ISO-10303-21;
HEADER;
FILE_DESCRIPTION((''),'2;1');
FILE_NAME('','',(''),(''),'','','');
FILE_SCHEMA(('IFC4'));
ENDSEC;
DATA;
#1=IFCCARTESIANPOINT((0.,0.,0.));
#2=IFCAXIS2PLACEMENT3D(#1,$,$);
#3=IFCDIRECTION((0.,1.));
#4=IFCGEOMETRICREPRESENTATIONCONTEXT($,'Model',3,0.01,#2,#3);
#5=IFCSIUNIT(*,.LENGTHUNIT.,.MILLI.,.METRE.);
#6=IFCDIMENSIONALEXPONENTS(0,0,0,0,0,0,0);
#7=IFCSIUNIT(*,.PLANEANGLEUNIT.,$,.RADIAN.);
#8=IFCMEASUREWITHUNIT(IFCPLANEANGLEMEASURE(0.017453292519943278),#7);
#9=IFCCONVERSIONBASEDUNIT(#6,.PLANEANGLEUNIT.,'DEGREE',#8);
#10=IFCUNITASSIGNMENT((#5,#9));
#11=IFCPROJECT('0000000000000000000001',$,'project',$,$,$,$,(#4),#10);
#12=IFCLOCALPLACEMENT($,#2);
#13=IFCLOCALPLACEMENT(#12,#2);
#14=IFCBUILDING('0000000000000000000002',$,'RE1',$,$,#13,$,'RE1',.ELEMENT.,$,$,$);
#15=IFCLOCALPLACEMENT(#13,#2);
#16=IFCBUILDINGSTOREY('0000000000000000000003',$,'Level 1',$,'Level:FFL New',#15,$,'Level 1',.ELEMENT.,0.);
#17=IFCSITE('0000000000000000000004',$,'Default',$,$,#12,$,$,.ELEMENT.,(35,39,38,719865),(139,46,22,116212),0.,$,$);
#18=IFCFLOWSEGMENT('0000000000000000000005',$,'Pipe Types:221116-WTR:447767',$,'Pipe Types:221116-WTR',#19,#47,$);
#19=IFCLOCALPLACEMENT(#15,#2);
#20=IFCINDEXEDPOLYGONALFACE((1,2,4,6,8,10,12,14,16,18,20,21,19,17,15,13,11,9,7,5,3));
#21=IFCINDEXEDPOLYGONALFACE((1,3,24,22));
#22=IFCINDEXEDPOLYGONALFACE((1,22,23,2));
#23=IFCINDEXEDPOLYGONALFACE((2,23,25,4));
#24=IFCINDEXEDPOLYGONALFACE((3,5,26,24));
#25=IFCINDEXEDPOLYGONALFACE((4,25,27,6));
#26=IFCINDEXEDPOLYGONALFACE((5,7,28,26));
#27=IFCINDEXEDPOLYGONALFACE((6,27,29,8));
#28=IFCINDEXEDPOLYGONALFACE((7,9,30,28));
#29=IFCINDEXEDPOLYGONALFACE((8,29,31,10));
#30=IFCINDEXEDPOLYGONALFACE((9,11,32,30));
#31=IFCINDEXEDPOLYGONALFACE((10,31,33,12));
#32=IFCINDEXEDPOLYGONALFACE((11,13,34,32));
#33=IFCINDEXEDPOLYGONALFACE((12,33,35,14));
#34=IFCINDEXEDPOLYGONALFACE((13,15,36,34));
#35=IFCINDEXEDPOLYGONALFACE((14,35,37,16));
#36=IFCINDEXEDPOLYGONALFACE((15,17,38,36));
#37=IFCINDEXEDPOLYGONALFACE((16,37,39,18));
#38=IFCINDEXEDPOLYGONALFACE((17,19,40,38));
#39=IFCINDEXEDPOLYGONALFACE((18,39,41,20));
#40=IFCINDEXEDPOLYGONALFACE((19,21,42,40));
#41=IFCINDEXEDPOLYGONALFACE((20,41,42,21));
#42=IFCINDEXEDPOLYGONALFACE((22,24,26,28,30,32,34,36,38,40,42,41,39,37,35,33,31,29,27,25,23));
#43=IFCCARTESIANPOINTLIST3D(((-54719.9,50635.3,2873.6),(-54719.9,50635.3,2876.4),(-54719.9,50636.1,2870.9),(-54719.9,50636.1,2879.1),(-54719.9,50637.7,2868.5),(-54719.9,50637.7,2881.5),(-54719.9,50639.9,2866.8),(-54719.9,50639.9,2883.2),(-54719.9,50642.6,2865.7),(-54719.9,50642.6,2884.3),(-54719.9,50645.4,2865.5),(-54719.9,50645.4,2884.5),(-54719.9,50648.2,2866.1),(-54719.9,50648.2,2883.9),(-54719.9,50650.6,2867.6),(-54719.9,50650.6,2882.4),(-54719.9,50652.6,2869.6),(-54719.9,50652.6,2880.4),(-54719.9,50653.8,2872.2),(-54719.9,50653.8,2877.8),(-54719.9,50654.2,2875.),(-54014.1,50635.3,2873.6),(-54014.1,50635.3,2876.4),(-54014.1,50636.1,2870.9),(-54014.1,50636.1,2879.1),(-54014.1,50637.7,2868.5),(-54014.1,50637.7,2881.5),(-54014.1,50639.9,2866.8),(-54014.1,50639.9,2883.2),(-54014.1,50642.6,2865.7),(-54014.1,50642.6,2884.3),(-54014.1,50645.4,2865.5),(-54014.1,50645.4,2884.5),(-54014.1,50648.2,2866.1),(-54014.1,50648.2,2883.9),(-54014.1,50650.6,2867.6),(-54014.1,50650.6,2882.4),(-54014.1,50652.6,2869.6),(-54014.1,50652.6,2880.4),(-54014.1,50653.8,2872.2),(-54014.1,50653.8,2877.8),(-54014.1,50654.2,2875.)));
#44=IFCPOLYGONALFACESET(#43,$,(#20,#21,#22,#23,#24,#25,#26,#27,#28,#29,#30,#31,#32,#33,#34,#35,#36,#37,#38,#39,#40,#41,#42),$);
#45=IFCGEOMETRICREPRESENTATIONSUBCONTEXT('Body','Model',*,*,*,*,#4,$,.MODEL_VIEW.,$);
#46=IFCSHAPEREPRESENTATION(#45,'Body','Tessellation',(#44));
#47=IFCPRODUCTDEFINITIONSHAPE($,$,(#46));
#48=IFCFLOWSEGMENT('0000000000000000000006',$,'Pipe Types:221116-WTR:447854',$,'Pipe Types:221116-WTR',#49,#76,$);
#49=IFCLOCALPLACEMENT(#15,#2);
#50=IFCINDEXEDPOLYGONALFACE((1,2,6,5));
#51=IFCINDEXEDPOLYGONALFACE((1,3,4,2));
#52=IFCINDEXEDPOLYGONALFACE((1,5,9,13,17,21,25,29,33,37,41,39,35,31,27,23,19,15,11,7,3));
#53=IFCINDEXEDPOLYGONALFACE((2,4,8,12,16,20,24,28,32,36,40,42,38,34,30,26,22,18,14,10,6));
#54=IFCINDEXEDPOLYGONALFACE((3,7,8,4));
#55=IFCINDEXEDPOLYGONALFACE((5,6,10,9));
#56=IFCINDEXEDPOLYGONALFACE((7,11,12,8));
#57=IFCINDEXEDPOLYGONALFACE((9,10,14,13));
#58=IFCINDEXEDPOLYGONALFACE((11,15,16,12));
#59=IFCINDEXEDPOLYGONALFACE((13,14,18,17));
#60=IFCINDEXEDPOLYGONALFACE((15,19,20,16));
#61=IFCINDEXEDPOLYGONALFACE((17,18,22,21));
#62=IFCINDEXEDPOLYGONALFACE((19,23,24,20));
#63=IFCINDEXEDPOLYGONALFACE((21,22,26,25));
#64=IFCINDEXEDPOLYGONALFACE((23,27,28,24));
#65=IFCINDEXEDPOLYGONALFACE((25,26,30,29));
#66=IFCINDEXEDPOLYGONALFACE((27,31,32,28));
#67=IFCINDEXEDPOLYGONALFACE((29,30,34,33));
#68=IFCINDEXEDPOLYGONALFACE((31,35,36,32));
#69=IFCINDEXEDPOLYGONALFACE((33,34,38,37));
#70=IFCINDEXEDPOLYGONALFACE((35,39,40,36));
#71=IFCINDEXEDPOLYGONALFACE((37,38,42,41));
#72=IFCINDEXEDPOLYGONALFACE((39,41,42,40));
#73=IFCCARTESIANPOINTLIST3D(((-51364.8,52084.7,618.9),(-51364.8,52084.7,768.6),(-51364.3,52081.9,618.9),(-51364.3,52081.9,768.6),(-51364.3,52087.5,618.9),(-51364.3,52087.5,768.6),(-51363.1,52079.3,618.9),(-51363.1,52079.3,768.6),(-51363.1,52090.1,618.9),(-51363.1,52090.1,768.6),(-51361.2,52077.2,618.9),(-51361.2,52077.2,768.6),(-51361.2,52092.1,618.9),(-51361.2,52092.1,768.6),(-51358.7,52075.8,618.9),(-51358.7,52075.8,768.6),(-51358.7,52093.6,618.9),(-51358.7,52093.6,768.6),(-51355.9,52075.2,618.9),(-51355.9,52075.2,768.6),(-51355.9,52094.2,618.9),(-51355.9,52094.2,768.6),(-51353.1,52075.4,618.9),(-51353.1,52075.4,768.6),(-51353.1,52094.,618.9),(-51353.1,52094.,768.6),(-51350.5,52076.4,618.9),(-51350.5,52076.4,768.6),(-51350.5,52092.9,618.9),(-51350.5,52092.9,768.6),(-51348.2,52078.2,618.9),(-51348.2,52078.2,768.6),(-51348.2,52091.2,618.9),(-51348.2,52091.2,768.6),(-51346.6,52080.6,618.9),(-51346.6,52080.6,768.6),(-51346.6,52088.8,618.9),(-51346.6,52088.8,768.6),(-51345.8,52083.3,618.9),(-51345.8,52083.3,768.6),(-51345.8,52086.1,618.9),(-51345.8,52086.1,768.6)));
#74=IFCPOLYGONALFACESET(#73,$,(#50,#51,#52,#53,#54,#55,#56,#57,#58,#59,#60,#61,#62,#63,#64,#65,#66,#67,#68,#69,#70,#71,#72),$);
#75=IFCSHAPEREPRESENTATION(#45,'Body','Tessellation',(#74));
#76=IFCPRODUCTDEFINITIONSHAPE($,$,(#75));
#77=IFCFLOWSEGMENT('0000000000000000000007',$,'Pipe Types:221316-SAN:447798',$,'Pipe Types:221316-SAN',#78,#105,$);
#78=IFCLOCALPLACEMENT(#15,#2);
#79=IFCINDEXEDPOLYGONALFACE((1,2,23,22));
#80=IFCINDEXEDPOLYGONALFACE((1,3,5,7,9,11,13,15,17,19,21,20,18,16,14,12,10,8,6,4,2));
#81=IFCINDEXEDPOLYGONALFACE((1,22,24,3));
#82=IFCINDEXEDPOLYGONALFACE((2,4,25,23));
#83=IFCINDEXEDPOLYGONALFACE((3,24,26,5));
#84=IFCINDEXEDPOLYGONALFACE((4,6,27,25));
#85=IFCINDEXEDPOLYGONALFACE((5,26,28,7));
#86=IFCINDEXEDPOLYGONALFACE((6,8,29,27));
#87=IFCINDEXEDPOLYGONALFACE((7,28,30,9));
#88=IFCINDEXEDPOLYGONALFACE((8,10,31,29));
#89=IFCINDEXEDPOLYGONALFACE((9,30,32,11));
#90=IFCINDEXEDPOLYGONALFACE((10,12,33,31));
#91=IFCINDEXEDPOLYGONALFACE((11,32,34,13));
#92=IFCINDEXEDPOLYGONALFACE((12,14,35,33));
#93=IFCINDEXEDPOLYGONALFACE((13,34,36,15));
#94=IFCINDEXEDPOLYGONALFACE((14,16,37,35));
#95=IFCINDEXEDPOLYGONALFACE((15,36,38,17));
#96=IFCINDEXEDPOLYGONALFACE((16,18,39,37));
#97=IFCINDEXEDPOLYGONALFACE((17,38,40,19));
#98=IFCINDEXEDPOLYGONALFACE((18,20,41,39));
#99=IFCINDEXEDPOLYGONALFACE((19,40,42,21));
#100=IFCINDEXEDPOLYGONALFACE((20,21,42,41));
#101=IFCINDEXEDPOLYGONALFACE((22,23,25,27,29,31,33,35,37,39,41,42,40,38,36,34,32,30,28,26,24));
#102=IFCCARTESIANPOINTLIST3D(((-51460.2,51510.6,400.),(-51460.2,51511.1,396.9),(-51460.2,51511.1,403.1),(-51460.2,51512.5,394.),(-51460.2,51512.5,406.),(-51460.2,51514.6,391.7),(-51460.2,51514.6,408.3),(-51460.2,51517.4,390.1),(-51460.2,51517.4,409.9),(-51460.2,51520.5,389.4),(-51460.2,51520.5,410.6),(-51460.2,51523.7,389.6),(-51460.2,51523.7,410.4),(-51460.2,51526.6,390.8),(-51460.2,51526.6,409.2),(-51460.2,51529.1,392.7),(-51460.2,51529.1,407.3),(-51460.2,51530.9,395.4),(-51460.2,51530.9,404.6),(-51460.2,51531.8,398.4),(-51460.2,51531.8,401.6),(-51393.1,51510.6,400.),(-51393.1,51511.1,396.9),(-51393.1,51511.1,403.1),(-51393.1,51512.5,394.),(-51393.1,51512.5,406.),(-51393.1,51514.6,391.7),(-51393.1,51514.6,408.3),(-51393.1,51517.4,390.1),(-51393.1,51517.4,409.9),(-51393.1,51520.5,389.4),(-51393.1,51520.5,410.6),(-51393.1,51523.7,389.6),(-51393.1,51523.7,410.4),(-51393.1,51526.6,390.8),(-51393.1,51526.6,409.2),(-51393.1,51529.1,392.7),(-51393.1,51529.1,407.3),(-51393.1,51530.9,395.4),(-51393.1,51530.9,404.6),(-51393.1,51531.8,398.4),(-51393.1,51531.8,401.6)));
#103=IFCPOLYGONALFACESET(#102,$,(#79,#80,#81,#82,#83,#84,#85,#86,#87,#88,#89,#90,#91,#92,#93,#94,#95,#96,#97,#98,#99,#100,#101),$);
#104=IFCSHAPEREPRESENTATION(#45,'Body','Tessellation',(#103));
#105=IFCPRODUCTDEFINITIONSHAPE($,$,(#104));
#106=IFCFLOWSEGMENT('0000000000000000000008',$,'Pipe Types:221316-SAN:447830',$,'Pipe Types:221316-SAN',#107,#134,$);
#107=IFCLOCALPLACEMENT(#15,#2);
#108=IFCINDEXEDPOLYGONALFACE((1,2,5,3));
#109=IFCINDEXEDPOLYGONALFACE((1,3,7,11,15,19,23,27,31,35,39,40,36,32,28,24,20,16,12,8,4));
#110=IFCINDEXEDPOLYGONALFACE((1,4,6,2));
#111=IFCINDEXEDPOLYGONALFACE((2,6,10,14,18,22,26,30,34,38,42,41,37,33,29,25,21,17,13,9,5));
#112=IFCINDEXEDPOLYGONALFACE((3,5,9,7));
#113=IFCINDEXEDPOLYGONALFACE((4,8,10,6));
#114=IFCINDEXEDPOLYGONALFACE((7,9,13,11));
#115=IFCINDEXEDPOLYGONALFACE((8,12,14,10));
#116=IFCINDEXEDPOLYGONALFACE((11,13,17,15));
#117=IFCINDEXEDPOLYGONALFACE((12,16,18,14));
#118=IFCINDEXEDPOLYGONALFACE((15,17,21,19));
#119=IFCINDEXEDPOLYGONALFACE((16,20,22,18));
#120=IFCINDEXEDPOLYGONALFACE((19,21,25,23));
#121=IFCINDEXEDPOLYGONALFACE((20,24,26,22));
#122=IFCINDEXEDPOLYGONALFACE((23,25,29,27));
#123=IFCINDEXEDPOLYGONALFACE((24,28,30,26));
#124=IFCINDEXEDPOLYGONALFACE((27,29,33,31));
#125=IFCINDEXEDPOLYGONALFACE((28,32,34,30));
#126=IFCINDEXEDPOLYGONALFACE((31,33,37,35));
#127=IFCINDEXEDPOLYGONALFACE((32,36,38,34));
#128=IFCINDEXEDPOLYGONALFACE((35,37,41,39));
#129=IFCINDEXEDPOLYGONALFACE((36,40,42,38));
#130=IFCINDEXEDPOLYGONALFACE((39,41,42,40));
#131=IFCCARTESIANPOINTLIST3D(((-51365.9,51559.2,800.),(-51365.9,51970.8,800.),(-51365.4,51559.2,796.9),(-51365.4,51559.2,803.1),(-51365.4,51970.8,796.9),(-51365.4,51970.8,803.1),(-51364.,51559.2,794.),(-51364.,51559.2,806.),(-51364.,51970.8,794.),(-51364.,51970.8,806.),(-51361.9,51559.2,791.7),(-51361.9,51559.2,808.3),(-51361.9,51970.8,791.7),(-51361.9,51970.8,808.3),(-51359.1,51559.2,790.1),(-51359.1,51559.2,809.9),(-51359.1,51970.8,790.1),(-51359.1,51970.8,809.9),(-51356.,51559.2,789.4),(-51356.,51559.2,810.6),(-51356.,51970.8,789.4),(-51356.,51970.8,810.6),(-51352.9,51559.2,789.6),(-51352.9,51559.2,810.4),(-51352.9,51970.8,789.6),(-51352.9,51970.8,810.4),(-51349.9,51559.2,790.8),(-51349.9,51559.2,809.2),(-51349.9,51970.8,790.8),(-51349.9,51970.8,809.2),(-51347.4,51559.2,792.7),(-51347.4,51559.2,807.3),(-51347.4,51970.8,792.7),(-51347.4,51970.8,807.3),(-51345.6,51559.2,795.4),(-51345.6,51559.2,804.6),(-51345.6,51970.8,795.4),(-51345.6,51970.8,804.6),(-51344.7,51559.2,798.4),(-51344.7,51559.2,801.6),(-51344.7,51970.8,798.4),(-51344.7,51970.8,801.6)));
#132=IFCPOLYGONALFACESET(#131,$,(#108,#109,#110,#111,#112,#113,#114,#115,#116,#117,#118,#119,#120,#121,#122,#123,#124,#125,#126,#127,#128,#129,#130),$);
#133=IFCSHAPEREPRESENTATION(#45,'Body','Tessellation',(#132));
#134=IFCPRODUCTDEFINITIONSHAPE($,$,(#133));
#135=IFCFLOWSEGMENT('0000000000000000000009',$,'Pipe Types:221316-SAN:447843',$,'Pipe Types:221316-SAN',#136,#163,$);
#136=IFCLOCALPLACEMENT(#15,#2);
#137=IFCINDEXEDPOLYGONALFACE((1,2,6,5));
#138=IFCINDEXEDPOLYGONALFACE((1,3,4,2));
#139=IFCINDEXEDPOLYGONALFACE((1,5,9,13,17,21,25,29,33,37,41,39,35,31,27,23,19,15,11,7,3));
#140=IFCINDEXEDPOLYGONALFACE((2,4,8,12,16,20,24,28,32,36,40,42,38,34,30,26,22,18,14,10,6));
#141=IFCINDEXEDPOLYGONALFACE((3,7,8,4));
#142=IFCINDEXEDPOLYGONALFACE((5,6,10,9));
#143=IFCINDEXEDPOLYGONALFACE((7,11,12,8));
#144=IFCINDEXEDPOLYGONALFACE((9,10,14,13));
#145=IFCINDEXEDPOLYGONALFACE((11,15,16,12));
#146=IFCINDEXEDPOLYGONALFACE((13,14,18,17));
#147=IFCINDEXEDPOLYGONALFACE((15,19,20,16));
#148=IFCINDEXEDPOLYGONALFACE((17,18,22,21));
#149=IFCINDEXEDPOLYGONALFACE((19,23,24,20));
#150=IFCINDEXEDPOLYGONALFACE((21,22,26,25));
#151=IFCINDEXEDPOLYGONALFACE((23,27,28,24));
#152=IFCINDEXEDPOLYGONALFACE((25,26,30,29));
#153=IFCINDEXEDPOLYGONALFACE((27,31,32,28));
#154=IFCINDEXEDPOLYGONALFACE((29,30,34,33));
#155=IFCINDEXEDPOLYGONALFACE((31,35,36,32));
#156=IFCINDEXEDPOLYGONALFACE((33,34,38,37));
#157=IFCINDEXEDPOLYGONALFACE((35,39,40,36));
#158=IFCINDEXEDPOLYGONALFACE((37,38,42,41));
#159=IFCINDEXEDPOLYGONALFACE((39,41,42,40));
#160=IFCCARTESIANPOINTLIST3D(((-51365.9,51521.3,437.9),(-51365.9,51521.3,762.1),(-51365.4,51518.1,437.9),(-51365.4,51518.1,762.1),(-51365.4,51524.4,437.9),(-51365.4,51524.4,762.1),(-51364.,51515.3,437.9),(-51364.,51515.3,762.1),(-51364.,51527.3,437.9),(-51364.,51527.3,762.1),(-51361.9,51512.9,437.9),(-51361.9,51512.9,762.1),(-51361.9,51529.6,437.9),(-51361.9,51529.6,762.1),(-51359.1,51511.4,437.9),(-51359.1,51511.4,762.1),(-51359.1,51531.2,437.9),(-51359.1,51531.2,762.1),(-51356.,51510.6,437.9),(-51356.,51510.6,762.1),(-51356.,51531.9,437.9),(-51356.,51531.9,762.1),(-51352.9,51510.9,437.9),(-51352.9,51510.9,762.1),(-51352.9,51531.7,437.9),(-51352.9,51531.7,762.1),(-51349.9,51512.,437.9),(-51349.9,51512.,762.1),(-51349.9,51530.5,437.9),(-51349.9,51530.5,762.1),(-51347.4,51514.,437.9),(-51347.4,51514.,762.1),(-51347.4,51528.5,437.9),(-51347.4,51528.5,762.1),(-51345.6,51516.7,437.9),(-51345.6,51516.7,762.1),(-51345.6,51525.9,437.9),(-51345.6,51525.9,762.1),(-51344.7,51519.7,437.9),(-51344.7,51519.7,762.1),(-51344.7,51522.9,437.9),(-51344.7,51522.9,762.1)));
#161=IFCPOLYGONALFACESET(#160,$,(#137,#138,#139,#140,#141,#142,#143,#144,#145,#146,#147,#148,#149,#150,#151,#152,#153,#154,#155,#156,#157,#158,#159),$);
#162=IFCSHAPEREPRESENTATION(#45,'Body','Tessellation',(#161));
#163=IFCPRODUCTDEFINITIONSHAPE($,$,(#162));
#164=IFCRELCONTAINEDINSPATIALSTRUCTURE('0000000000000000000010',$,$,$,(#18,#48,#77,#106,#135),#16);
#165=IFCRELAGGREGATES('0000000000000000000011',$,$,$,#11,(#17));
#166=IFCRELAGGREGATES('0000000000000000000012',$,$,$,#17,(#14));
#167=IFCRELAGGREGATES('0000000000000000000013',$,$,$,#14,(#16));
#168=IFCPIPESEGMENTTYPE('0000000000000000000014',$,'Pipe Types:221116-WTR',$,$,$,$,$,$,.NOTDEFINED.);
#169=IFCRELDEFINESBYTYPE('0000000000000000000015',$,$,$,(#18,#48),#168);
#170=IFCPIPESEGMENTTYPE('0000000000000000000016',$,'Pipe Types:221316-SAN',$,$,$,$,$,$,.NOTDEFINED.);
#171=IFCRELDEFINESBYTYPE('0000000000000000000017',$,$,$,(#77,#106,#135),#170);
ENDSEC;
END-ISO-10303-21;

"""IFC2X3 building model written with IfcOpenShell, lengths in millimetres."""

from ifc_helpers import new_model, entity, si_unit, converted_unit, direction, frame, frame_2d, origin, origin_2d_with_axis, place, context, subcontext, project, spatial, circle, extrude, type_object, element, save


model = new_model("IFC2X3")

# Units and contexts
model_context = context("Model", 3, precision=0.01, world=origin(), true_north=direction((0.0, 1.0)))
body_context = subcontext(model_context, "Body", "Model", "MODEL_VIEW")
ifc_project = project(units=[si_unit("LENGTHUNIT", "METRE", prefix="MILLI"), converted_unit("PLANEANGLEUNIT", "DEGREE", entity("IfcPlaneAngleMeasure", 0.017453292519943278), si_unit("PLANEANGLEUNIT", "RADIAN"), dimensions=[0, 0, 0, 0, 0, 0, 0])], contexts=[model_context])

# Site, building, storey
site_placement = place(None, origin())
site = spatial("IfcSite", under=ifc_project, at=site_placement, Name="Default", CompositionType="ELEMENT", RefLatitude=(35, 39, 38, 719865), RefLongitude=(139, 46, 22, 116212), RefElevation=0.0)
building_placement = place(site_placement, origin())
building = spatial("IfcBuilding", under=site, at=building_placement, Name="RE1", LongName="RE1", CompositionType="ELEMENT")
storey_placement = place(building_placement, origin())
storey = spatial("IfcBuildingStorey", under=building, at=storey_placement, Name="Level 1", ObjectType="Level:FFL New", LongName="Level 1", CompositionType="ELEMENT", Elevation=0.0)

# Flow segments
pipe_segment_type_1 = type_object("IfcPipeSegmentType", Name="Pipe Types:221116-WTR", PredefinedType="NOTDEFINED")
flow_segment_1_placement = place(storey_placement, origin())
element("IfcFlowSegment", 1, at=flow_segment_1_placement, inside=storey, type_object=pipe_segment_type_1, Name="Pipe Types:221116-WTR:447767", ObjectType="Pipe Types:221116-WTR", context=body_context, shape_type="SweptSolid", body=[
    extrude(circle(Radius=9.5, at=frame_2d((0.0, 0.0), x_axis=(1.0, 0.0))), frame((-54719.9, 50644.7, 2875.0), z_axis=(1.0, 0.0, 0.0), x_axis=(0.0, 1.0, 0.0)), (0.0, 0.0, 1.0), 705.7),
])
flow_segment_2_placement = place(storey_placement, origin())
element("IfcFlowSegment", 2, at=flow_segment_2_placement, inside=storey, type_object=pipe_segment_type_1, Name="Pipe Types:221116-WTR:447854", ObjectType="Pipe Types:221116-WTR", context=body_context, shape_type="SweptSolid", body=[
    extrude(circle(Radius=9.5, at=origin_2d_with_axis()), frame((-51355.2, 52084.7, 618.9), z_axis=(0.0, 0.0, 1.0), x_axis=(-1.0, 0.0, 0.0)), (0.0, 0.0, 1.0), 149.7),
])
pipe_segment_type_2 = type_object("IfcPipeSegmentType", Name="Pipe Types:221316-SAN", PredefinedType="NOTDEFINED")
flow_segment_3_placement = place(storey_placement, origin())
element("IfcFlowSegment", 3, at=flow_segment_3_placement, inside=storey, type_object=pipe_segment_type_2, Name="Pipe Types:221316-SAN:447798", ObjectType="Pipe Types:221316-SAN", context=body_context, shape_type="SweptSolid", body=[
    extrude(circle(Radius=10.7, at=origin_2d_with_axis()), frame((-51460.2, 51521.3, 400.0), z_axis=(1.0, 0.0, 0.0), x_axis=(0.0, -1.0, 0.0)), (0.0, 0.0, 1.0), 67.1),
])
flow_segment_4_placement = place(storey_placement, origin())
element("IfcFlowSegment", 4, at=flow_segment_4_placement, inside=storey, type_object=pipe_segment_type_2, Name="Pipe Types:221316-SAN:447830", ObjectType="Pipe Types:221316-SAN", context=body_context, shape_type="SweptSolid", body=[
    extrude(circle(Radius=10.7, at=origin_2d_with_axis()), frame((-51355.2, 51559.2, 800.0), z_axis=(0.0, 1.0, 0.0), x_axis=(-1.0, 0.0, 0.0)), (0.0, 0.0, 1.0), 411.7),
])
flow_segment_5_placement = place(storey_placement, origin())
element("IfcFlowSegment", 5, at=flow_segment_5_placement, inside=storey, type_object=pipe_segment_type_2, Name="Pipe Types:221316-SAN:447843", ObjectType="Pipe Types:221316-SAN", context=body_context, shape_type="SweptSolid", body=[
    extrude(circle(Radius=10.7, at=frame_2d((0.0, 0.0), x_axis=(1.0, 0.0))), frame((-51355.2, 51521.3, 437.9), z_axis=(0.0, 0.0, 1.0), x_axis=(-1.0, 0.0, 0.0)), (0.0, 0.0, 1.0), 324.3),
])

save(model, "model.ifc")
